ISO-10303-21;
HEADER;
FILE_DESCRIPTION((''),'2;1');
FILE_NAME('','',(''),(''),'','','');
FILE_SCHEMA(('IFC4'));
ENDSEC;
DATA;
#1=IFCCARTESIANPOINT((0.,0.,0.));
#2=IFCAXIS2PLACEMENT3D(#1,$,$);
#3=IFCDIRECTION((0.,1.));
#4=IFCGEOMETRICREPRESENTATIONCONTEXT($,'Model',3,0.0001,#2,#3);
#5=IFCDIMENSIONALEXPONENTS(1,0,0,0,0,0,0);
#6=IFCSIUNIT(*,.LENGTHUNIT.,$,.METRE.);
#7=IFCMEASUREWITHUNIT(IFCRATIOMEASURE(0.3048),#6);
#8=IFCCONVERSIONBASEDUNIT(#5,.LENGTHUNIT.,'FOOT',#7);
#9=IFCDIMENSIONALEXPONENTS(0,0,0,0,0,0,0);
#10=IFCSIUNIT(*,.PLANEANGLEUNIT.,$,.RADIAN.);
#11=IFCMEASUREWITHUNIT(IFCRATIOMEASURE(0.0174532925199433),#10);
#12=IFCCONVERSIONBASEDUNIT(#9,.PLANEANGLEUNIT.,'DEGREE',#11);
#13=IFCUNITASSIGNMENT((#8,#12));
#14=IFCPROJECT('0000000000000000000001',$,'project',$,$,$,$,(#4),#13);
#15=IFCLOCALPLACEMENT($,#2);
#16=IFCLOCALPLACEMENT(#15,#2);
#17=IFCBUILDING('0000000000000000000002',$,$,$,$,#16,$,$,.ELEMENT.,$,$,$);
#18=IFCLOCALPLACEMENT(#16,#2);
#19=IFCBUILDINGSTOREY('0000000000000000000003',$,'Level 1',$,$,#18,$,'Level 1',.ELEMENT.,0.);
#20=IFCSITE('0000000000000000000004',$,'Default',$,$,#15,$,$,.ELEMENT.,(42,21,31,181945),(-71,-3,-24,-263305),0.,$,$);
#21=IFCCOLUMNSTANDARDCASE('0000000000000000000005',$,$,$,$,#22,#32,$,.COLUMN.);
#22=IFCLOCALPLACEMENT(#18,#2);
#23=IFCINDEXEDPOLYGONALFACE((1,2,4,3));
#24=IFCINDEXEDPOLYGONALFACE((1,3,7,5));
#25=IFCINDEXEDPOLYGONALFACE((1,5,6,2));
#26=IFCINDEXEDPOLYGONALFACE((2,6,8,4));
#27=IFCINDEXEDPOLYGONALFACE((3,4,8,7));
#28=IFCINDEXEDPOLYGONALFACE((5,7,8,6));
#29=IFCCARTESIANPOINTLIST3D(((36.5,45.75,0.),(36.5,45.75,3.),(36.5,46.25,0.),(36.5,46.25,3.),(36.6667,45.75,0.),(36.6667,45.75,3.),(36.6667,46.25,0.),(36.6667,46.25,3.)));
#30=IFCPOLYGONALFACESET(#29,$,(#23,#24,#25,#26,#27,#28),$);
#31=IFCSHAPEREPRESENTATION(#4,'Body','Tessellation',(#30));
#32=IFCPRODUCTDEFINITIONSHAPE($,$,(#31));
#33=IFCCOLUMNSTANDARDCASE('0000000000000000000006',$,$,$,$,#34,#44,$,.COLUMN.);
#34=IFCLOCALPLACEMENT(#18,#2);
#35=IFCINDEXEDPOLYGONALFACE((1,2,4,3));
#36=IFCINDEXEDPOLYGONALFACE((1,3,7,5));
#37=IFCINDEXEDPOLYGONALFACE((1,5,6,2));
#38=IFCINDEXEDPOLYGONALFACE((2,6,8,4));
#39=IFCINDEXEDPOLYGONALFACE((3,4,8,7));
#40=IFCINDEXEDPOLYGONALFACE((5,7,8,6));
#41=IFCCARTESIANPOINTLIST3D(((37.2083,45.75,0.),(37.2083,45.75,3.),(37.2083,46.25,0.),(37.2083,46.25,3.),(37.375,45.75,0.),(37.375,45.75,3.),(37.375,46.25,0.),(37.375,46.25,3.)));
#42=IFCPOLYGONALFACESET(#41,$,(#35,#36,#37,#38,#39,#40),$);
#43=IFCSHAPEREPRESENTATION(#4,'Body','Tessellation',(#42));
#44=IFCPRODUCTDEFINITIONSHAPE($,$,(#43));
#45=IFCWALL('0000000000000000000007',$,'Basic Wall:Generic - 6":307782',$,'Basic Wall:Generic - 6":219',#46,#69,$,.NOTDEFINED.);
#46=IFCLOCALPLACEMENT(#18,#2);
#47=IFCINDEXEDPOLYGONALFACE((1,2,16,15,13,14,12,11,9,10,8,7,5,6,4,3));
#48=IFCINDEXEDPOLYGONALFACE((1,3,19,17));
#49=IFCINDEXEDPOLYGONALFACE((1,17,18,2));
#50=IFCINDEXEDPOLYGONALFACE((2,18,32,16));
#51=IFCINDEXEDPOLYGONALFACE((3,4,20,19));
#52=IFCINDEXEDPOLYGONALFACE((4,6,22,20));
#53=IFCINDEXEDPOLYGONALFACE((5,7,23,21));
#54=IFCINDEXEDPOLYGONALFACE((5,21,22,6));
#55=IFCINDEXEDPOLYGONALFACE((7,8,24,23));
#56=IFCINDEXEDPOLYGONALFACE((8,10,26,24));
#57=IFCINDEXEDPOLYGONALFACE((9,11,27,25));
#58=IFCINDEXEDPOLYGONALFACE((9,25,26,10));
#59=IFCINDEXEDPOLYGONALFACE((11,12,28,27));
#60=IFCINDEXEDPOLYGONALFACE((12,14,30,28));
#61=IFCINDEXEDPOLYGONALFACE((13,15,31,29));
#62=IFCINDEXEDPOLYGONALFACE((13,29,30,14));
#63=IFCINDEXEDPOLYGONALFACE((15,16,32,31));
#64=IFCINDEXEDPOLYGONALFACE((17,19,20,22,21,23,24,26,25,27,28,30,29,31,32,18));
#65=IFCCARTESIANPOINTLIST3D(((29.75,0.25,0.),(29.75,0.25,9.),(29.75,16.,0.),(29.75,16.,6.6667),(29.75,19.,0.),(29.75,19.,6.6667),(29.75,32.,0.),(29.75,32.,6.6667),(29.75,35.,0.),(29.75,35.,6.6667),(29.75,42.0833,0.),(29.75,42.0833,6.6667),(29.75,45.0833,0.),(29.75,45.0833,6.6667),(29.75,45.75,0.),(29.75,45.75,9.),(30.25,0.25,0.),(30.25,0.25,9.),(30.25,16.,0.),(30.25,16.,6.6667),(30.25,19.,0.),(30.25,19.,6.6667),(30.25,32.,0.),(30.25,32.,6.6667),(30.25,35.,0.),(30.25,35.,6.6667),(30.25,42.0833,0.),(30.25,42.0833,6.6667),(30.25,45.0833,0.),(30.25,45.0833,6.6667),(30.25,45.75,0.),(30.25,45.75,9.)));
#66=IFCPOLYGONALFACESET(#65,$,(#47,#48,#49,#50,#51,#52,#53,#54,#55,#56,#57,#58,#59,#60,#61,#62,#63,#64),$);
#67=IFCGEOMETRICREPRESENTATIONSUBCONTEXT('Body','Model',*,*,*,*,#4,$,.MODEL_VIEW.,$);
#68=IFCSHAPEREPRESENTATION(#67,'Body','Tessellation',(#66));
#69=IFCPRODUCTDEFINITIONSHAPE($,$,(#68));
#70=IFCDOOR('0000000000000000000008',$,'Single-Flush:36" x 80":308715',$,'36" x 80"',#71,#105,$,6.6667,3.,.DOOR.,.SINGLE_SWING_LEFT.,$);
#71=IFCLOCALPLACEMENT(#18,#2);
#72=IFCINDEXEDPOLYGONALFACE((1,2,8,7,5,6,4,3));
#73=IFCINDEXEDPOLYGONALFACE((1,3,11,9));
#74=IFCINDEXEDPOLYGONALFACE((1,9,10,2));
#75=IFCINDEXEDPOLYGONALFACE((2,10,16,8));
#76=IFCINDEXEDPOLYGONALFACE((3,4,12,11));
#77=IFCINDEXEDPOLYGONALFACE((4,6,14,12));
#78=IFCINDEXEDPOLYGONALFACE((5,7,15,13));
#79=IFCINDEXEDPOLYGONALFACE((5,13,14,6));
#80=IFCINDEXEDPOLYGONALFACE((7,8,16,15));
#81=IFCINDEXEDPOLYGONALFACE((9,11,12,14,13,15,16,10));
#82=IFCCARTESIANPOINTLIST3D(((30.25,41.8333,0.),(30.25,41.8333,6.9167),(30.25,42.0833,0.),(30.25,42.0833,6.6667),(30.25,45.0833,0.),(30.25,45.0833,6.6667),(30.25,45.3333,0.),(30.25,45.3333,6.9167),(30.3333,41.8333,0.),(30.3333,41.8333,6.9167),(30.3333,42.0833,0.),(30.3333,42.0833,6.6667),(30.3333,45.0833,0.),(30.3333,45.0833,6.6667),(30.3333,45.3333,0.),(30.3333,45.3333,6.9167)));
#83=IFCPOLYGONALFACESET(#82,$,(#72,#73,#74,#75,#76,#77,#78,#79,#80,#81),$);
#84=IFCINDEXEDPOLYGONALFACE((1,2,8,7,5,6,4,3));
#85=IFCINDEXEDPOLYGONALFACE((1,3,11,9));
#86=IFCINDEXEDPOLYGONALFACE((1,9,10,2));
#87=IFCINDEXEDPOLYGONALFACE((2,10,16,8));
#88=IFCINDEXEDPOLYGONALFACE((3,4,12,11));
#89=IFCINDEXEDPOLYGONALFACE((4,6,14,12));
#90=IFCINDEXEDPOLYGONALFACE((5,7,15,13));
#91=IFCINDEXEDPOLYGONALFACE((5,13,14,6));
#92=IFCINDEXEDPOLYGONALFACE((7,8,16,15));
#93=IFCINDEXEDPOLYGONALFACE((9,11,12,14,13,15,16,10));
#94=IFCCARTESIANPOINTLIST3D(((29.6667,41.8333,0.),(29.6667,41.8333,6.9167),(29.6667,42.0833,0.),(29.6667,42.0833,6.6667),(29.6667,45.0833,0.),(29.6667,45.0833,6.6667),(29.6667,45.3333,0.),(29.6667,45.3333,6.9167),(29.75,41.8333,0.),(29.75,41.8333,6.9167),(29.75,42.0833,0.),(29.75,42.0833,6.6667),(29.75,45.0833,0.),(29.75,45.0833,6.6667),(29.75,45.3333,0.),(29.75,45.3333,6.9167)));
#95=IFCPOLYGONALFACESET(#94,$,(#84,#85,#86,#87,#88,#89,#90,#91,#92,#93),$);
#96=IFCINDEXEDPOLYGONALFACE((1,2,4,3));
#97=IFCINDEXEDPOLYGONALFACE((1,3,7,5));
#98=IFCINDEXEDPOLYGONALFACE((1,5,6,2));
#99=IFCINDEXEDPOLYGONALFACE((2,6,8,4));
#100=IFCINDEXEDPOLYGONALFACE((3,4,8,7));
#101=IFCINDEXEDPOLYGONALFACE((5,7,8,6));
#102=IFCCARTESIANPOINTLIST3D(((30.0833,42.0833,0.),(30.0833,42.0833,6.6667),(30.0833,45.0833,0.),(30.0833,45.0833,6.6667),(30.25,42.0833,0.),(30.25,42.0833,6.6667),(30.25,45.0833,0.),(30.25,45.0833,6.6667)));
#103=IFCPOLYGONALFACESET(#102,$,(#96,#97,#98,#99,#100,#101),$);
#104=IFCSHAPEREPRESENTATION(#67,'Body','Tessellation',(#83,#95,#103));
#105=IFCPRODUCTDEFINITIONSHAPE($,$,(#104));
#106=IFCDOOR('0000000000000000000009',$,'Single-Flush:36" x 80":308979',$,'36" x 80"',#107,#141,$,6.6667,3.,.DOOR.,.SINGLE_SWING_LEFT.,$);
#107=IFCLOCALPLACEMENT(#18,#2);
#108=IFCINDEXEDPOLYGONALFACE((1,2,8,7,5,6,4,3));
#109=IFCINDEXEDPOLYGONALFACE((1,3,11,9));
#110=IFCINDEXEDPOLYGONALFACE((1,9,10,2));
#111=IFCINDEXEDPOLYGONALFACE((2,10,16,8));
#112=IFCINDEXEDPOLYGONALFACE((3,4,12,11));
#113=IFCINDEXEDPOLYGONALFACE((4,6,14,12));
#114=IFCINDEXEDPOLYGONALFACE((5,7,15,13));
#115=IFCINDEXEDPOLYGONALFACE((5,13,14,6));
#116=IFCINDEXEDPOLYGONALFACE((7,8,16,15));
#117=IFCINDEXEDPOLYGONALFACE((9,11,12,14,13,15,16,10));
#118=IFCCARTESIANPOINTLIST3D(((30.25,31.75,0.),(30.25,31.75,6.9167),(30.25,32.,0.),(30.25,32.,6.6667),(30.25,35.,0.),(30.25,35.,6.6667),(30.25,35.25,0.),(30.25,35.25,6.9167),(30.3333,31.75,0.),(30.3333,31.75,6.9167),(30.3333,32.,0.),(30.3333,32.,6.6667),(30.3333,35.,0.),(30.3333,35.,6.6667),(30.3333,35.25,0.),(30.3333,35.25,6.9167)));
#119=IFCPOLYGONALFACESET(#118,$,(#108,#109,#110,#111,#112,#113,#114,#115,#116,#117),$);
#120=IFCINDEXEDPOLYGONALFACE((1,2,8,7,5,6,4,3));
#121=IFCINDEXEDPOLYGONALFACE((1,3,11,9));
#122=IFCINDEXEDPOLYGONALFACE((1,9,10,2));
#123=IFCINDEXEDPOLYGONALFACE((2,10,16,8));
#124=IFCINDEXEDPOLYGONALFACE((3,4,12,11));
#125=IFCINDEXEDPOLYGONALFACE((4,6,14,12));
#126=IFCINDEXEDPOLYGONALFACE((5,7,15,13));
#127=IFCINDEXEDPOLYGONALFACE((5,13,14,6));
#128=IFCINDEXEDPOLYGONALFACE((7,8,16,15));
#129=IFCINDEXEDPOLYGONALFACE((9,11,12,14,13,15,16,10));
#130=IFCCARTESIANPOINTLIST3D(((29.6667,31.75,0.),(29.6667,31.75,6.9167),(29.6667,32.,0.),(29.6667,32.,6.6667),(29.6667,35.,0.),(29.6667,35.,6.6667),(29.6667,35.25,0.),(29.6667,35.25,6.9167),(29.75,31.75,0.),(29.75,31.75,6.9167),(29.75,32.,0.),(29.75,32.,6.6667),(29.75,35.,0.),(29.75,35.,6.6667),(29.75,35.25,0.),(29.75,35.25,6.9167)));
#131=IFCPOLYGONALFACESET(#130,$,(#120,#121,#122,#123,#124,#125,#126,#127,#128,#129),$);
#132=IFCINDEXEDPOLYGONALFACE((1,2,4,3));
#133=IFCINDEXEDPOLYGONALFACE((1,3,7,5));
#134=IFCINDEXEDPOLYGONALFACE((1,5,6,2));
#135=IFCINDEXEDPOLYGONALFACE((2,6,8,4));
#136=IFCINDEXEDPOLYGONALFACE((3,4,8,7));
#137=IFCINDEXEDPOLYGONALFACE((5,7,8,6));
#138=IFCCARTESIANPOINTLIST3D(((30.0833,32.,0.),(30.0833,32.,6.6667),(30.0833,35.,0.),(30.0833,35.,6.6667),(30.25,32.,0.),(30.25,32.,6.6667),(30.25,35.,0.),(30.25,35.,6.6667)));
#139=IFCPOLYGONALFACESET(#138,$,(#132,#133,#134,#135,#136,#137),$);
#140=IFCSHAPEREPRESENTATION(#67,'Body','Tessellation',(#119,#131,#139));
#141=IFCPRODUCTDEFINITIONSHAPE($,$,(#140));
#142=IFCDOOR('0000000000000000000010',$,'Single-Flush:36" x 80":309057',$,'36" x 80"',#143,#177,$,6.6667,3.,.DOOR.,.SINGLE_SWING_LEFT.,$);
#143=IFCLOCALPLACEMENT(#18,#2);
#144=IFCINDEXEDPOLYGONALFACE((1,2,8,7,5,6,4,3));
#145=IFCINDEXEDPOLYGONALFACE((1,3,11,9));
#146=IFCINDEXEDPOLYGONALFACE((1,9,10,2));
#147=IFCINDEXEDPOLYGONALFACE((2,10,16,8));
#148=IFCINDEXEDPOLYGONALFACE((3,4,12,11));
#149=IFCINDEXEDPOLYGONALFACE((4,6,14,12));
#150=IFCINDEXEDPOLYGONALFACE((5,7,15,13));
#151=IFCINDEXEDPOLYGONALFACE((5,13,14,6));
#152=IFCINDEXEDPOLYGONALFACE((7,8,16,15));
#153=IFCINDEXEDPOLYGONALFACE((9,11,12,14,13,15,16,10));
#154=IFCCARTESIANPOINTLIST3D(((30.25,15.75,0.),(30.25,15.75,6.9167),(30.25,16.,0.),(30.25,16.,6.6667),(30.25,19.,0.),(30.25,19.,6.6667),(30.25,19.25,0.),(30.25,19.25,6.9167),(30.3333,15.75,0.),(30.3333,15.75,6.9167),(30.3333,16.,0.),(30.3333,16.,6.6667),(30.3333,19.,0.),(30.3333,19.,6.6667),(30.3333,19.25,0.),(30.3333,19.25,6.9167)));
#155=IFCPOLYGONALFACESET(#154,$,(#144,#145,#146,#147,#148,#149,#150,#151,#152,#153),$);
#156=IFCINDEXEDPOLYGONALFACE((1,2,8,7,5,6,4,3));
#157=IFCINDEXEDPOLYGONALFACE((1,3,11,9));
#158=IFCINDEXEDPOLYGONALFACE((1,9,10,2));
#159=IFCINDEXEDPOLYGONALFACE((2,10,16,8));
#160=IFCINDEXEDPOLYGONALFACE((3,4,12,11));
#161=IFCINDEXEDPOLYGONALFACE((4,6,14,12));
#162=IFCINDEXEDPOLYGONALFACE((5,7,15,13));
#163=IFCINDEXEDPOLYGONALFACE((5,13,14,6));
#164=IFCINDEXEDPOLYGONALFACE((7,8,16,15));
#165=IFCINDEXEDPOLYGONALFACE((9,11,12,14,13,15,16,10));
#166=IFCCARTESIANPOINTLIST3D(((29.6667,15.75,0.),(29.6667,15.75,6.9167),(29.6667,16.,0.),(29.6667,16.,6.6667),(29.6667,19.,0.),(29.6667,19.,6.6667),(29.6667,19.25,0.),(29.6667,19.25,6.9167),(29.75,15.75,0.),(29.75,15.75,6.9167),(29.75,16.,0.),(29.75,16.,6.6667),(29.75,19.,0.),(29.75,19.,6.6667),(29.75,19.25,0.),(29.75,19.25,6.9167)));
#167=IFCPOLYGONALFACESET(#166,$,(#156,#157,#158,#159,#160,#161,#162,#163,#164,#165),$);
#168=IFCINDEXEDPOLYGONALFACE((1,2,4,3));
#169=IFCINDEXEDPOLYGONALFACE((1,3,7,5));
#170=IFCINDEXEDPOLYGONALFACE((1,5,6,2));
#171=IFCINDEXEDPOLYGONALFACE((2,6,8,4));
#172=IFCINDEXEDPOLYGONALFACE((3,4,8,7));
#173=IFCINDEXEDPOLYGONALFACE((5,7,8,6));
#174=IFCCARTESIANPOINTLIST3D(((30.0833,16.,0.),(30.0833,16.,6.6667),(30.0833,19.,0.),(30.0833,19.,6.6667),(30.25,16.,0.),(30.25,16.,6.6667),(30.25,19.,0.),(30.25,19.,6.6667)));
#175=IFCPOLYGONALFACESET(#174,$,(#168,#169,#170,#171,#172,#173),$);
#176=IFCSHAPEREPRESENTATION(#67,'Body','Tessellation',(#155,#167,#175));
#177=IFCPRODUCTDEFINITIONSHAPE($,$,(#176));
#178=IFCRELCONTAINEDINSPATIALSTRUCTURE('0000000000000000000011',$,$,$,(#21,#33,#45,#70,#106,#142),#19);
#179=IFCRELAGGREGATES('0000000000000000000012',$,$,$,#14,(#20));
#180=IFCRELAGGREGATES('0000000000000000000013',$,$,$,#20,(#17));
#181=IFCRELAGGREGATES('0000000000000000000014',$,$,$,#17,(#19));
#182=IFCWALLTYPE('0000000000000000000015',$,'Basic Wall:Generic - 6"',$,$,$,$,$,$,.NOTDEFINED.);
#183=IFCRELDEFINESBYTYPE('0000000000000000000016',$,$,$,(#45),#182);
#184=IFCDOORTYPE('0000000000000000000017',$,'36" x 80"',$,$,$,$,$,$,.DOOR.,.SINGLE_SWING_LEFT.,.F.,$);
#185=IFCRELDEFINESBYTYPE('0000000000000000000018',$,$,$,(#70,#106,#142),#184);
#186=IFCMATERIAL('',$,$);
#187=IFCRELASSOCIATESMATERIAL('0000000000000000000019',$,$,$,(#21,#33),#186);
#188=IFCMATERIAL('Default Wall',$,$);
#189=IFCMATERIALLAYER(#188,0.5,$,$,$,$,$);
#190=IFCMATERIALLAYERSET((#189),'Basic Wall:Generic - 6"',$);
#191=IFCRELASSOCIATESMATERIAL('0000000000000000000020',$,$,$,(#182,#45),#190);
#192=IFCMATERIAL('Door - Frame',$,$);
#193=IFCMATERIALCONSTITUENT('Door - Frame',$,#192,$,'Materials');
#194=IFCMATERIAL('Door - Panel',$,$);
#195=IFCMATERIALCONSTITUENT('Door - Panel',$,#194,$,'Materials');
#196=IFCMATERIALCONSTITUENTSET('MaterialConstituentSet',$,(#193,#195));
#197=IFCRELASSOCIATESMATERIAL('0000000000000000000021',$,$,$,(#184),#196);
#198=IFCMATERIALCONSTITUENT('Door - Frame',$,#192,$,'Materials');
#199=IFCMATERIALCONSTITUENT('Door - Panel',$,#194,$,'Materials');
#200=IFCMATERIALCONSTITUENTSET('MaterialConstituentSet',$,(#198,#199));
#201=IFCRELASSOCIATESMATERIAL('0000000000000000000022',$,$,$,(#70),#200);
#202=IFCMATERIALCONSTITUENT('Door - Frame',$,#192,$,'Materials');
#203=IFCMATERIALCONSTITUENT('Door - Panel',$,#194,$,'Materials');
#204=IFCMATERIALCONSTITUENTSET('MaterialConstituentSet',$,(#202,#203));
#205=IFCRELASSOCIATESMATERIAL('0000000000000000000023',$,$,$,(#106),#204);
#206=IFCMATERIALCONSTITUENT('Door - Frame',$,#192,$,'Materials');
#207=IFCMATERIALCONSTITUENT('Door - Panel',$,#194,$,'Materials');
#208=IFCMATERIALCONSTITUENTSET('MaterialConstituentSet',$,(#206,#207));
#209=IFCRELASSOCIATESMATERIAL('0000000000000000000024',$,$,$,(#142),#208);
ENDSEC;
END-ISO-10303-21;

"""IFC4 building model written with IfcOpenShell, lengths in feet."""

from ifc_helpers import new_model, entity, si_unit, converted_unit, direction, frame, frame_2d, origin, origin_2d_with_axis, place, context, subcontext, project, spatial, polyline, rectangle, outline, extrude, clip, bounded_halfspace, source, transform, mapped, material, layer, layer_set, layer_usage, constituent, constituent_set, type_object, type_shapes, element, fill, save


model = new_model("IFC4")

# Units and contexts
model_context = context("Model", 3, precision=0.0001, world=origin(), true_north=direction((0.0, 1.0)))
body_context = subcontext(model_context, "Body", "Model", "MODEL_VIEW")
ifc_project = project(units=[converted_unit("LENGTHUNIT", "FOOT", entity("IfcRatioMeasure", 0.3048), si_unit("LENGTHUNIT", "METRE"), dimensions=[1, 0, 0, 0, 0, 0, 0]), converted_unit("PLANEANGLEUNIT", "DEGREE", entity("IfcRatioMeasure", 0.0174532925199433), si_unit("PLANEANGLEUNIT", "RADIAN"), dimensions=[0, 0, 0, 0, 0, 0, 0])], contexts=[model_context])

# Site, building, storey
site_placement = place(None, origin())
site = spatial("IfcSite", under=ifc_project, at=site_placement, Name="Default", CompositionType="ELEMENT", RefLatitude=(42, 21, 31, 181945), RefLongitude=(-71, -3, -24, -263305), RefElevation=0.0)
building_placement = place(site_placement, origin())
building = spatial("IfcBuilding", under=site, at=building_placement, CompositionType="ELEMENT")
storey_placement = place(building_placement, origin())
storey = spatial("IfcBuildingStorey", under=building, at=storey_placement, Name="Level 1", LongName="Level 1", CompositionType="ELEMENT", Elevation=0.0)

# Columns
placement = place(storey_placement, frame((-0.25, 46.0, 0.0)))
ifc_material_1 = material(Name="")
for number, where, z_axis, x_axis in (
    (1, (36.8334, 0.0, 0.0), (0.0, 0.0, 1.0), (1.0, 0.0, 0.0)),
    (2, (37.5417, 0.0, 0.0), (0.0, 0.0, 1.0), (1.0, 0.0, 0.0)),
):
    element("IfcColumnStandardCase", number, at=place(placement, frame(where, z_axis=z_axis, x_axis=x_axis)), inside=storey, material=ifc_material_1, PredefinedType="COLUMN", context=model_context, shape_type="SweptSolid", body=[
        extrude(rectangle(XDim=0.1667, YDim=0.5), origin(), (0.0, 0.0, 1.0), 3.0),
    ])
wall_placement = place(storey_placement, frame((30.0, 45.75, 0.0), z_axis=(0.0, 0.0, 1.0), x_axis=(0.0, -1.0, 0.0)))

# Wall, openings, doors
ifc_material_2 = material(Name="Default Wall")
ifc_layer = layer(ifc_material_2, 0.5)
ifc_layer_set = layer_set([ifc_layer], Name="Basic Wall:Generic - 6\"")
ifc_layer_usage = layer_usage(ifc_layer_set, "AXIS2", "NEGATIVE", 0.25)
wall_type = type_object("IfcWallType", Name="Basic Wall:Generic - 6\"", PredefinedType="NOTDEFINED", material=ifc_layer_set)
wall = element("IfcWall", 3, at=wall_placement, inside=storey, type_object=wall_type, material=ifc_layer_usage, Name="Basic Wall:Generic - 6\":307782", ObjectType="Basic Wall:Generic - 6\":219", PredefinedType="NOTDEFINED", context=body_context, shape_type="Clipping", body=[
    clip(clip(clip(extrude(rectangle(XDim=45.5, YDim=0.5, at=frame_2d((22.75, 0.0), x_axis=(-1.0, 0.0))), origin(), (0.0, 0.0, 1.0), 9.0), bounded_halfspace(frame((34.0, -0.25, 9.0), z_axis=(0.0, 0.0, -1.0), x_axis=(0.0, 1.0, 0.0)), True, frame((34.0, -0.25, 9.0)), polyline([(0.0, 0.0), (11.5, 0.0), (11.5, 0.5), (0.0, 0.5), (0.0, 0.0)]))), bounded_halfspace(frame((25.5, -0.25, 9.0), z_axis=(0.0, 0.0, -1.0), x_axis=(-1.0, 0.0, 0.0)), True, frame((25.5, -0.25, 9.0)), polyline([(0.0, 0.0), (0.0, 0.5), (-15.5, 0.5), (-16.0, 0.5), (-25.5, 0.5), (-25.5, 0.0), (0.0, 0.0)]))), bounded_halfspace(frame((34.0, -0.25, 9.0), z_axis=(0.0, 0.0, -1.0), x_axis=(1.0, 0.0, 0.0)), True, frame((34.0, -0.25, 9.0)), polyline([(0.0, 0.0), (0.0, 0.5), (-8.0, 0.5), (-8.5, 0.5), (-8.5, 0.0), (-0.5, 0.0), (0.0, 0.0)]))),
])
opening_1_placement = place(wall_placement, frame((0.6667, -0.25, 0.0)))
opening_1 = element("IfcOpeningElement", 4, at=opening_1_placement, cuts=wall, ObjectType="Opening", PredefinedType="OPENING", context=body_context, shape_type="SweptSolid", body=[
    extrude(rectangle(XDim=3.0, YDim=6.6667, at=frame_2d((3.3333, 1.5), x_axis=(0.0, -1.0))), frame((0.0, 0.0, 0.0), z_axis=(0.0, 1.0, 0.0), x_axis=(0.0, 0.0, 1.0)), (0.0, 0.0, 1.0), 0.5),
])
opening_2_placement = place(wall_placement, frame((10.75, -0.25, 0.0)))
opening_2 = element("IfcOpeningElement", 5, at=opening_2_placement, cuts=wall, ObjectType="Opening", PredefinedType="OPENING", context=body_context, shape_type="SweptSolid", body=[
    extrude(rectangle(XDim=3.0, YDim=6.6667, at=frame_2d((3.3333, 1.5), x_axis=(0.0, -1.0))), frame((0.0, 0.0, 0.0), z_axis=(0.0, 1.0, 0.0), x_axis=(0.0, 0.0, 1.0)), (0.0, 0.0, 1.0), 0.5),
])
opening_3_placement = place(wall_placement, frame((26.75, -0.25, 0.0)))
opening_3 = element("IfcOpeningElement", 6, at=opening_3_placement, cuts=wall, ObjectType="Opening", PredefinedType="OPENING", context=body_context, shape_type="SweptSolid", body=[
    extrude(rectangle(XDim=3.0, YDim=6.6667, at=frame_2d((3.3333, 1.5), x_axis=(0.0, -1.0))), frame((0.0, 0.0, 0.0), z_axis=(0.0, 1.0, 0.0), x_axis=(0.0, 0.0, 1.0)), (0.0, 0.0, 1.0), 0.5),
])
ifc_material_3 = material(Name="Door - Frame")
ifc_constituent_1 = constituent(ifc_material_3, Name="Door - Frame", Category="Materials")
ifc_material_4 = material(Name="Door - Panel")
ifc_constituent_2 = constituent(ifc_material_4, Name="Door - Panel", Category="Materials")
ifc_constituent_set_1 = constituent_set(constituents=[ifc_constituent_1, ifc_constituent_2], Name="MaterialConstituentSet")
ifc_constituent_3 = constituent(ifc_material_3, Name="Door - Frame", Category="Materials")
ifc_constituent_4 = constituent(ifc_material_4, Name="Door - Panel", Category="Materials")
ifc_constituent_set_2 = constituent_set(constituents=[ifc_constituent_3, ifc_constituent_4], Name="MaterialConstituentSet")
door_type = type_object("IfcDoorType", Name="36\" x 80\"", OperationType="SINGLE_SWING_LEFT", ParameterTakesPrecedence=False, PredefinedType="DOOR", material=ifc_constituent_set_2)
shared_shape = source(origin(), body_context, "Body", "SweptSolid", [
    extrude(outline(polyline([(-1.75, -3.5208), (1.75, -3.5208), (1.75, 3.3958), (1.5, 3.3958), (1.5, -3.2708), (-1.5, -3.2708), (-1.5, 3.3958), (-1.75, 3.3958), (-1.75, -3.5208)])), frame((1.5, 0.5833, 3.3958), z_axis=(0.0, -1.0, 0.0), x_axis=(-1.0, 0.0, 0.0)), (0.0, 0.0, 1.0), 0.0833),
    extrude(outline(polyline([(-3.5208, -1.75), (3.3958, -1.75), (3.3958, -1.5), (-3.2708, -1.5), (-3.2708, 1.5), (3.3958, 1.5), (3.3958, 1.75), (-3.5208, 1.75), (-3.5208, -1.75)])), frame((1.5, 0.0, 3.3958), z_axis=(0.0, -1.0, 0.0), x_axis=(0.0, 0.0, -1.0)), (0.0, 0.0, 1.0), 0.0833),
    extrude(rectangle(XDim=3.0, YDim=0.1667, at=origin_2d_with_axis()), frame((1.5, 0.4167, 0.0)), (0.0, 0.0, 1.0), 6.6667),
])
type_shapes(door_type, [shared_shape])
door_1_placement = place(opening_1_placement, origin())
door_1 = element("IfcDoor", 7, at=door_1_placement, inside=storey, type_object=door_type, material=ifc_constituent_set_1, Name="Single-Flush:36\" x 80\":308715", ObjectType="36\" x 80\"", OperationType="SINGLE_SWING_LEFT", OverallHeight=6.6667, OverallWidth=3.0, PredefinedType="DOOR", context=body_context, shape_type="MappedRepresentation", body=[
    mapped(shared_shape, transform((0.0, 0.0, 0.0), scale=1.0)),
])
fill(opening_1, door_1)
ifc_constituent_5 = constituent(ifc_material_3, Name="Door - Frame", Category="Materials")
ifc_constituent_6 = constituent(ifc_material_4, Name="Door - Panel", Category="Materials")
ifc_constituent_set_3 = constituent_set(constituents=[ifc_constituent_5, ifc_constituent_6], Name="MaterialConstituentSet")
door_2_placement = place(opening_2_placement, origin())
door_2 = element("IfcDoor", 8, at=door_2_placement, inside=storey, type_object=door_type, material=ifc_constituent_set_3, Name="Single-Flush:36\" x 80\":308979", ObjectType="36\" x 80\"", OperationType="SINGLE_SWING_LEFT", OverallHeight=6.6667, OverallWidth=3.0, PredefinedType="DOOR", context=body_context, shape_type="MappedRepresentation", body=[
    mapped(shared_shape, transform((0.0, 0.0, 0.0), scale=1.0)),
])
fill(opening_2, door_2)
ifc_constituent_7 = constituent(ifc_material_3, Name="Door - Frame", Category="Materials")
ifc_constituent_8 = constituent(ifc_material_4, Name="Door - Panel", Category="Materials")
ifc_constituent_set_4 = constituent_set(constituents=[ifc_constituent_7, ifc_constituent_8], Name="MaterialConstituentSet")
door_3_placement = place(opening_3_placement, origin())
door_3 = element("IfcDoor", 9, at=door_3_placement, inside=storey, type_object=door_type, material=ifc_constituent_set_4, Name="Single-Flush:36\" x 80\":309057", ObjectType="36\" x 80\"", OperationType="SINGLE_SWING_LEFT", OverallHeight=6.6667, OverallWidth=3.0, PredefinedType="DOOR", context=body_context, shape_type="MappedRepresentation", body=[
    mapped(shared_shape, transform((0.0, 0.0, 0.0), scale=1.0)),
])
fill(opening_3, door_3)

save(model, "model.ifc")
